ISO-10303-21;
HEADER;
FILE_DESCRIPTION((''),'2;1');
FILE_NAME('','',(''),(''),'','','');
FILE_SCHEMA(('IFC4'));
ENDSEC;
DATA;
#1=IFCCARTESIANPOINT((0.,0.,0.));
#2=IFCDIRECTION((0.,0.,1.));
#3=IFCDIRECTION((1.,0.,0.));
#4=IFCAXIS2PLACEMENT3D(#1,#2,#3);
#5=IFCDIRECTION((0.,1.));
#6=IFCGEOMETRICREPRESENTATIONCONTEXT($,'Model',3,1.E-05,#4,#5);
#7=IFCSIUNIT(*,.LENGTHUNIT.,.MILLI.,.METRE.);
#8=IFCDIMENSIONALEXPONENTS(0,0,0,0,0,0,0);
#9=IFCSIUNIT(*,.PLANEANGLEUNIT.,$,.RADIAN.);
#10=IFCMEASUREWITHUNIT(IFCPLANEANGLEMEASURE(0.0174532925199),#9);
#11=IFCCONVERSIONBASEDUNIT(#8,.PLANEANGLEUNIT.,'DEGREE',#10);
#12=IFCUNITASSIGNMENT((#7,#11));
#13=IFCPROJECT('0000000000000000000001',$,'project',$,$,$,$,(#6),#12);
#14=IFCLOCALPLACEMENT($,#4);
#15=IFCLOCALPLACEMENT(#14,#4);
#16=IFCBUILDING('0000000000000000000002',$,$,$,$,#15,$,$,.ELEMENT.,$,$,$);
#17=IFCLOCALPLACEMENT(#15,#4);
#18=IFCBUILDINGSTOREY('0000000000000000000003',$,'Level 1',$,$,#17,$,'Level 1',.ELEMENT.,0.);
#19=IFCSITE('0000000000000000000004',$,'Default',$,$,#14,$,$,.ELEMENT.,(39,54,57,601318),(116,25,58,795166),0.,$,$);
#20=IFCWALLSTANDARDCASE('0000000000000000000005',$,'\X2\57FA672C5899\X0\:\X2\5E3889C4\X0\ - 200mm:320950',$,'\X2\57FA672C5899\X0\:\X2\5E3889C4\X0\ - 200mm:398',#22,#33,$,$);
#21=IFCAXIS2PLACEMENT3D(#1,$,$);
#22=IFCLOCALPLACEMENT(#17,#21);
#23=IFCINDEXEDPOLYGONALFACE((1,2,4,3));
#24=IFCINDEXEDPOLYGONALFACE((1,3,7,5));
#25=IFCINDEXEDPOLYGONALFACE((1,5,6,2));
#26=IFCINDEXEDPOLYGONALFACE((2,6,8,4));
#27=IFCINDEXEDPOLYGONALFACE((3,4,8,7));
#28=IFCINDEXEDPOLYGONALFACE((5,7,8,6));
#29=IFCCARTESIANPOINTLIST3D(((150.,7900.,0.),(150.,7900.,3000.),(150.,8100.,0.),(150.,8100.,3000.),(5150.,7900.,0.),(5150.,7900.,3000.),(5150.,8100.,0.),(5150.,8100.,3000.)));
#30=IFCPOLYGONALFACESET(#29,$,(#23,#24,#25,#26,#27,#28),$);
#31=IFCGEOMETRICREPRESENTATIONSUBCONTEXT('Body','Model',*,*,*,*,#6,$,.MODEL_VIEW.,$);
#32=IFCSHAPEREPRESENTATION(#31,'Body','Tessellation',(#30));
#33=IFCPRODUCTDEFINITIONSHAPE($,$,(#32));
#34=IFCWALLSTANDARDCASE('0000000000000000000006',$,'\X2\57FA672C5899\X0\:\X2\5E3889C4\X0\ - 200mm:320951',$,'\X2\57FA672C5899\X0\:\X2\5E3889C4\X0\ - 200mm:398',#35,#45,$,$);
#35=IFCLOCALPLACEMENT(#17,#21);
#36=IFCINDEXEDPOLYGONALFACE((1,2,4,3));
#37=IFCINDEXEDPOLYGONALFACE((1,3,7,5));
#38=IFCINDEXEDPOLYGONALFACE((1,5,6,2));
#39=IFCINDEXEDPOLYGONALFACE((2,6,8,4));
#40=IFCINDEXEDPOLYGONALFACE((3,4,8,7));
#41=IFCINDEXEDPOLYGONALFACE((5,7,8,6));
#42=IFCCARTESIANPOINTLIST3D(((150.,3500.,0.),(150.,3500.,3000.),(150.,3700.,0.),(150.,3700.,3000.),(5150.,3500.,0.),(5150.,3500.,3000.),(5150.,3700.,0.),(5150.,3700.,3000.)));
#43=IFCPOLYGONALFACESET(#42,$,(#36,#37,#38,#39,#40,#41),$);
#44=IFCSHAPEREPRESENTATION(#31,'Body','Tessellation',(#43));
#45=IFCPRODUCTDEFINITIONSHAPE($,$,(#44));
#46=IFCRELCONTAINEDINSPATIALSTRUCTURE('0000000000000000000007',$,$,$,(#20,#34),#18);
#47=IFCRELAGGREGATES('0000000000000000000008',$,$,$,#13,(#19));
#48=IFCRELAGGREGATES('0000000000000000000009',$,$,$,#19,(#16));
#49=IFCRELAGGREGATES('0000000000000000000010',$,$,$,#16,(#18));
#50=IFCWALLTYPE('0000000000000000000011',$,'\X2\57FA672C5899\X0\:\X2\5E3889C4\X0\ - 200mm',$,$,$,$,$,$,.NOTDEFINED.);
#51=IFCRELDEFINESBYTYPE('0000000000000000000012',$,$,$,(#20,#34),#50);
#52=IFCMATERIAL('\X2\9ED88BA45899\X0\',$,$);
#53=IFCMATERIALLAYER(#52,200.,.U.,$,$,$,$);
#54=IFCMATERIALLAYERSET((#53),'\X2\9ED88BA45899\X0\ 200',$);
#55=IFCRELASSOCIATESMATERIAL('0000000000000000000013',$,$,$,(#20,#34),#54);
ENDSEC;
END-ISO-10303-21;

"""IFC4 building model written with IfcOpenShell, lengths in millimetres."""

from ifc_helpers import new_model, entity, si_unit, converted_unit, direction, frame, origin_with_axes, place, context, subcontext, project, spatial, polyline, outline, extrude, material, layer, layer_set, layer_usage, type_object, element, save


model = new_model("IFC4")

# Units and contexts
model_context = context("Model", 3, precision=1e-05, world=origin_with_axes(), true_north=direction((0.0, 1.0)))
body_context = subcontext(model_context, "Body", "Model", "MODEL_VIEW")
ifc_project = project(units=[si_unit("LENGTHUNIT", "METRE", prefix="MILLI"), converted_unit("PLANEANGLEUNIT", "DEGREE", entity("IfcPlaneAngleMeasure", 0.0174532925199), si_unit("PLANEANGLEUNIT", "RADIAN"), dimensions=[0, 0, 0, 0, 0, 0, 0])], contexts=[model_context])

# Site, building, storey
site_placement = place(None, origin_with_axes())
site = spatial("IfcSite", under=ifc_project, at=site_placement, Name="Default", CompositionType="ELEMENT", RefLatitude=(39, 54, 57, 601318), RefLongitude=(116, 25, 58, 795166), RefElevation=0.0)
building_placement = place(site_placement, origin_with_axes())
building = spatial("IfcBuilding", under=site, at=building_placement, CompositionType="ELEMENT")
storey_placement = place(building_placement, origin_with_axes())
storey = spatial("IfcBuildingStorey", under=building, at=storey_placement, Name="Level 1", LongName="Level 1", CompositionType="ELEMENT", Elevation=0.0)

# Shared definitions
ifc_material = material(Name="默认墙")
ifc_layer = layer(ifc_material, 200.0, ventilated="UNKNOWN")
ifc_layer_set = layer_set([ifc_layer], Name="默认墙 200")
wall_type = type_object("IfcWallType", Name="基本墙:常规 - 200mm", PredefinedType="NOTDEFINED")

# Walls
ifc_layer_usage_1 = layer_usage(ifc_layer_set, "AXIS2", "POSITIVE", -100.0)
wall_1_placement = place(storey_placement, frame((150.0, 8000.0, 0.0), z_axis=(0.0, 0.0, 1.0), x_axis=(1.0, 0.0, 0.0)))
element("IfcWallStandardCase", 1, at=wall_1_placement, inside=storey, type_object=wall_type, material=ifc_layer_usage_1, Name="基本墙:常规 - 200mm:320950", ObjectType="基本墙:常规 - 200mm:398", context=body_context, shape_type="SweptSolid", body=[
    extrude(outline(polyline([(0.0, -100.0), (5000.0, -100.0), (5000.0, 100.0), (0.0, 100.0), (0.0, -100.0)])), origin_with_axes(), (0.0, 0.0, 1.0), 3000.0),
])
ifc_layer_usage_2 = layer_usage(ifc_layer_set, "AXIS2", "POSITIVE", -100.0)
wall_2_placement = place(storey_placement, frame((150.0, 3600.0, 0.0), z_axis=(0.0, 0.0, 1.0), x_axis=(1.0, 0.0, 0.0)))
element("IfcWallStandardCase", 2, at=wall_2_placement, inside=storey, type_object=wall_type, material=ifc_layer_usage_2, Name="基本墙:常规 - 200mm:320951", ObjectType="基本墙:常规 - 200mm:398", context=body_context, shape_type="SweptSolid", body=[
    extrude(outline(polyline([(0.0, -100.0), (5000.0, -100.0), (5000.0, 100.0), (0.0, 100.0), (0.0, -100.0)])), origin_with_axes(), (0.0, 0.0, 1.0), 3000.0),
])

save(model, "model.ifc")
